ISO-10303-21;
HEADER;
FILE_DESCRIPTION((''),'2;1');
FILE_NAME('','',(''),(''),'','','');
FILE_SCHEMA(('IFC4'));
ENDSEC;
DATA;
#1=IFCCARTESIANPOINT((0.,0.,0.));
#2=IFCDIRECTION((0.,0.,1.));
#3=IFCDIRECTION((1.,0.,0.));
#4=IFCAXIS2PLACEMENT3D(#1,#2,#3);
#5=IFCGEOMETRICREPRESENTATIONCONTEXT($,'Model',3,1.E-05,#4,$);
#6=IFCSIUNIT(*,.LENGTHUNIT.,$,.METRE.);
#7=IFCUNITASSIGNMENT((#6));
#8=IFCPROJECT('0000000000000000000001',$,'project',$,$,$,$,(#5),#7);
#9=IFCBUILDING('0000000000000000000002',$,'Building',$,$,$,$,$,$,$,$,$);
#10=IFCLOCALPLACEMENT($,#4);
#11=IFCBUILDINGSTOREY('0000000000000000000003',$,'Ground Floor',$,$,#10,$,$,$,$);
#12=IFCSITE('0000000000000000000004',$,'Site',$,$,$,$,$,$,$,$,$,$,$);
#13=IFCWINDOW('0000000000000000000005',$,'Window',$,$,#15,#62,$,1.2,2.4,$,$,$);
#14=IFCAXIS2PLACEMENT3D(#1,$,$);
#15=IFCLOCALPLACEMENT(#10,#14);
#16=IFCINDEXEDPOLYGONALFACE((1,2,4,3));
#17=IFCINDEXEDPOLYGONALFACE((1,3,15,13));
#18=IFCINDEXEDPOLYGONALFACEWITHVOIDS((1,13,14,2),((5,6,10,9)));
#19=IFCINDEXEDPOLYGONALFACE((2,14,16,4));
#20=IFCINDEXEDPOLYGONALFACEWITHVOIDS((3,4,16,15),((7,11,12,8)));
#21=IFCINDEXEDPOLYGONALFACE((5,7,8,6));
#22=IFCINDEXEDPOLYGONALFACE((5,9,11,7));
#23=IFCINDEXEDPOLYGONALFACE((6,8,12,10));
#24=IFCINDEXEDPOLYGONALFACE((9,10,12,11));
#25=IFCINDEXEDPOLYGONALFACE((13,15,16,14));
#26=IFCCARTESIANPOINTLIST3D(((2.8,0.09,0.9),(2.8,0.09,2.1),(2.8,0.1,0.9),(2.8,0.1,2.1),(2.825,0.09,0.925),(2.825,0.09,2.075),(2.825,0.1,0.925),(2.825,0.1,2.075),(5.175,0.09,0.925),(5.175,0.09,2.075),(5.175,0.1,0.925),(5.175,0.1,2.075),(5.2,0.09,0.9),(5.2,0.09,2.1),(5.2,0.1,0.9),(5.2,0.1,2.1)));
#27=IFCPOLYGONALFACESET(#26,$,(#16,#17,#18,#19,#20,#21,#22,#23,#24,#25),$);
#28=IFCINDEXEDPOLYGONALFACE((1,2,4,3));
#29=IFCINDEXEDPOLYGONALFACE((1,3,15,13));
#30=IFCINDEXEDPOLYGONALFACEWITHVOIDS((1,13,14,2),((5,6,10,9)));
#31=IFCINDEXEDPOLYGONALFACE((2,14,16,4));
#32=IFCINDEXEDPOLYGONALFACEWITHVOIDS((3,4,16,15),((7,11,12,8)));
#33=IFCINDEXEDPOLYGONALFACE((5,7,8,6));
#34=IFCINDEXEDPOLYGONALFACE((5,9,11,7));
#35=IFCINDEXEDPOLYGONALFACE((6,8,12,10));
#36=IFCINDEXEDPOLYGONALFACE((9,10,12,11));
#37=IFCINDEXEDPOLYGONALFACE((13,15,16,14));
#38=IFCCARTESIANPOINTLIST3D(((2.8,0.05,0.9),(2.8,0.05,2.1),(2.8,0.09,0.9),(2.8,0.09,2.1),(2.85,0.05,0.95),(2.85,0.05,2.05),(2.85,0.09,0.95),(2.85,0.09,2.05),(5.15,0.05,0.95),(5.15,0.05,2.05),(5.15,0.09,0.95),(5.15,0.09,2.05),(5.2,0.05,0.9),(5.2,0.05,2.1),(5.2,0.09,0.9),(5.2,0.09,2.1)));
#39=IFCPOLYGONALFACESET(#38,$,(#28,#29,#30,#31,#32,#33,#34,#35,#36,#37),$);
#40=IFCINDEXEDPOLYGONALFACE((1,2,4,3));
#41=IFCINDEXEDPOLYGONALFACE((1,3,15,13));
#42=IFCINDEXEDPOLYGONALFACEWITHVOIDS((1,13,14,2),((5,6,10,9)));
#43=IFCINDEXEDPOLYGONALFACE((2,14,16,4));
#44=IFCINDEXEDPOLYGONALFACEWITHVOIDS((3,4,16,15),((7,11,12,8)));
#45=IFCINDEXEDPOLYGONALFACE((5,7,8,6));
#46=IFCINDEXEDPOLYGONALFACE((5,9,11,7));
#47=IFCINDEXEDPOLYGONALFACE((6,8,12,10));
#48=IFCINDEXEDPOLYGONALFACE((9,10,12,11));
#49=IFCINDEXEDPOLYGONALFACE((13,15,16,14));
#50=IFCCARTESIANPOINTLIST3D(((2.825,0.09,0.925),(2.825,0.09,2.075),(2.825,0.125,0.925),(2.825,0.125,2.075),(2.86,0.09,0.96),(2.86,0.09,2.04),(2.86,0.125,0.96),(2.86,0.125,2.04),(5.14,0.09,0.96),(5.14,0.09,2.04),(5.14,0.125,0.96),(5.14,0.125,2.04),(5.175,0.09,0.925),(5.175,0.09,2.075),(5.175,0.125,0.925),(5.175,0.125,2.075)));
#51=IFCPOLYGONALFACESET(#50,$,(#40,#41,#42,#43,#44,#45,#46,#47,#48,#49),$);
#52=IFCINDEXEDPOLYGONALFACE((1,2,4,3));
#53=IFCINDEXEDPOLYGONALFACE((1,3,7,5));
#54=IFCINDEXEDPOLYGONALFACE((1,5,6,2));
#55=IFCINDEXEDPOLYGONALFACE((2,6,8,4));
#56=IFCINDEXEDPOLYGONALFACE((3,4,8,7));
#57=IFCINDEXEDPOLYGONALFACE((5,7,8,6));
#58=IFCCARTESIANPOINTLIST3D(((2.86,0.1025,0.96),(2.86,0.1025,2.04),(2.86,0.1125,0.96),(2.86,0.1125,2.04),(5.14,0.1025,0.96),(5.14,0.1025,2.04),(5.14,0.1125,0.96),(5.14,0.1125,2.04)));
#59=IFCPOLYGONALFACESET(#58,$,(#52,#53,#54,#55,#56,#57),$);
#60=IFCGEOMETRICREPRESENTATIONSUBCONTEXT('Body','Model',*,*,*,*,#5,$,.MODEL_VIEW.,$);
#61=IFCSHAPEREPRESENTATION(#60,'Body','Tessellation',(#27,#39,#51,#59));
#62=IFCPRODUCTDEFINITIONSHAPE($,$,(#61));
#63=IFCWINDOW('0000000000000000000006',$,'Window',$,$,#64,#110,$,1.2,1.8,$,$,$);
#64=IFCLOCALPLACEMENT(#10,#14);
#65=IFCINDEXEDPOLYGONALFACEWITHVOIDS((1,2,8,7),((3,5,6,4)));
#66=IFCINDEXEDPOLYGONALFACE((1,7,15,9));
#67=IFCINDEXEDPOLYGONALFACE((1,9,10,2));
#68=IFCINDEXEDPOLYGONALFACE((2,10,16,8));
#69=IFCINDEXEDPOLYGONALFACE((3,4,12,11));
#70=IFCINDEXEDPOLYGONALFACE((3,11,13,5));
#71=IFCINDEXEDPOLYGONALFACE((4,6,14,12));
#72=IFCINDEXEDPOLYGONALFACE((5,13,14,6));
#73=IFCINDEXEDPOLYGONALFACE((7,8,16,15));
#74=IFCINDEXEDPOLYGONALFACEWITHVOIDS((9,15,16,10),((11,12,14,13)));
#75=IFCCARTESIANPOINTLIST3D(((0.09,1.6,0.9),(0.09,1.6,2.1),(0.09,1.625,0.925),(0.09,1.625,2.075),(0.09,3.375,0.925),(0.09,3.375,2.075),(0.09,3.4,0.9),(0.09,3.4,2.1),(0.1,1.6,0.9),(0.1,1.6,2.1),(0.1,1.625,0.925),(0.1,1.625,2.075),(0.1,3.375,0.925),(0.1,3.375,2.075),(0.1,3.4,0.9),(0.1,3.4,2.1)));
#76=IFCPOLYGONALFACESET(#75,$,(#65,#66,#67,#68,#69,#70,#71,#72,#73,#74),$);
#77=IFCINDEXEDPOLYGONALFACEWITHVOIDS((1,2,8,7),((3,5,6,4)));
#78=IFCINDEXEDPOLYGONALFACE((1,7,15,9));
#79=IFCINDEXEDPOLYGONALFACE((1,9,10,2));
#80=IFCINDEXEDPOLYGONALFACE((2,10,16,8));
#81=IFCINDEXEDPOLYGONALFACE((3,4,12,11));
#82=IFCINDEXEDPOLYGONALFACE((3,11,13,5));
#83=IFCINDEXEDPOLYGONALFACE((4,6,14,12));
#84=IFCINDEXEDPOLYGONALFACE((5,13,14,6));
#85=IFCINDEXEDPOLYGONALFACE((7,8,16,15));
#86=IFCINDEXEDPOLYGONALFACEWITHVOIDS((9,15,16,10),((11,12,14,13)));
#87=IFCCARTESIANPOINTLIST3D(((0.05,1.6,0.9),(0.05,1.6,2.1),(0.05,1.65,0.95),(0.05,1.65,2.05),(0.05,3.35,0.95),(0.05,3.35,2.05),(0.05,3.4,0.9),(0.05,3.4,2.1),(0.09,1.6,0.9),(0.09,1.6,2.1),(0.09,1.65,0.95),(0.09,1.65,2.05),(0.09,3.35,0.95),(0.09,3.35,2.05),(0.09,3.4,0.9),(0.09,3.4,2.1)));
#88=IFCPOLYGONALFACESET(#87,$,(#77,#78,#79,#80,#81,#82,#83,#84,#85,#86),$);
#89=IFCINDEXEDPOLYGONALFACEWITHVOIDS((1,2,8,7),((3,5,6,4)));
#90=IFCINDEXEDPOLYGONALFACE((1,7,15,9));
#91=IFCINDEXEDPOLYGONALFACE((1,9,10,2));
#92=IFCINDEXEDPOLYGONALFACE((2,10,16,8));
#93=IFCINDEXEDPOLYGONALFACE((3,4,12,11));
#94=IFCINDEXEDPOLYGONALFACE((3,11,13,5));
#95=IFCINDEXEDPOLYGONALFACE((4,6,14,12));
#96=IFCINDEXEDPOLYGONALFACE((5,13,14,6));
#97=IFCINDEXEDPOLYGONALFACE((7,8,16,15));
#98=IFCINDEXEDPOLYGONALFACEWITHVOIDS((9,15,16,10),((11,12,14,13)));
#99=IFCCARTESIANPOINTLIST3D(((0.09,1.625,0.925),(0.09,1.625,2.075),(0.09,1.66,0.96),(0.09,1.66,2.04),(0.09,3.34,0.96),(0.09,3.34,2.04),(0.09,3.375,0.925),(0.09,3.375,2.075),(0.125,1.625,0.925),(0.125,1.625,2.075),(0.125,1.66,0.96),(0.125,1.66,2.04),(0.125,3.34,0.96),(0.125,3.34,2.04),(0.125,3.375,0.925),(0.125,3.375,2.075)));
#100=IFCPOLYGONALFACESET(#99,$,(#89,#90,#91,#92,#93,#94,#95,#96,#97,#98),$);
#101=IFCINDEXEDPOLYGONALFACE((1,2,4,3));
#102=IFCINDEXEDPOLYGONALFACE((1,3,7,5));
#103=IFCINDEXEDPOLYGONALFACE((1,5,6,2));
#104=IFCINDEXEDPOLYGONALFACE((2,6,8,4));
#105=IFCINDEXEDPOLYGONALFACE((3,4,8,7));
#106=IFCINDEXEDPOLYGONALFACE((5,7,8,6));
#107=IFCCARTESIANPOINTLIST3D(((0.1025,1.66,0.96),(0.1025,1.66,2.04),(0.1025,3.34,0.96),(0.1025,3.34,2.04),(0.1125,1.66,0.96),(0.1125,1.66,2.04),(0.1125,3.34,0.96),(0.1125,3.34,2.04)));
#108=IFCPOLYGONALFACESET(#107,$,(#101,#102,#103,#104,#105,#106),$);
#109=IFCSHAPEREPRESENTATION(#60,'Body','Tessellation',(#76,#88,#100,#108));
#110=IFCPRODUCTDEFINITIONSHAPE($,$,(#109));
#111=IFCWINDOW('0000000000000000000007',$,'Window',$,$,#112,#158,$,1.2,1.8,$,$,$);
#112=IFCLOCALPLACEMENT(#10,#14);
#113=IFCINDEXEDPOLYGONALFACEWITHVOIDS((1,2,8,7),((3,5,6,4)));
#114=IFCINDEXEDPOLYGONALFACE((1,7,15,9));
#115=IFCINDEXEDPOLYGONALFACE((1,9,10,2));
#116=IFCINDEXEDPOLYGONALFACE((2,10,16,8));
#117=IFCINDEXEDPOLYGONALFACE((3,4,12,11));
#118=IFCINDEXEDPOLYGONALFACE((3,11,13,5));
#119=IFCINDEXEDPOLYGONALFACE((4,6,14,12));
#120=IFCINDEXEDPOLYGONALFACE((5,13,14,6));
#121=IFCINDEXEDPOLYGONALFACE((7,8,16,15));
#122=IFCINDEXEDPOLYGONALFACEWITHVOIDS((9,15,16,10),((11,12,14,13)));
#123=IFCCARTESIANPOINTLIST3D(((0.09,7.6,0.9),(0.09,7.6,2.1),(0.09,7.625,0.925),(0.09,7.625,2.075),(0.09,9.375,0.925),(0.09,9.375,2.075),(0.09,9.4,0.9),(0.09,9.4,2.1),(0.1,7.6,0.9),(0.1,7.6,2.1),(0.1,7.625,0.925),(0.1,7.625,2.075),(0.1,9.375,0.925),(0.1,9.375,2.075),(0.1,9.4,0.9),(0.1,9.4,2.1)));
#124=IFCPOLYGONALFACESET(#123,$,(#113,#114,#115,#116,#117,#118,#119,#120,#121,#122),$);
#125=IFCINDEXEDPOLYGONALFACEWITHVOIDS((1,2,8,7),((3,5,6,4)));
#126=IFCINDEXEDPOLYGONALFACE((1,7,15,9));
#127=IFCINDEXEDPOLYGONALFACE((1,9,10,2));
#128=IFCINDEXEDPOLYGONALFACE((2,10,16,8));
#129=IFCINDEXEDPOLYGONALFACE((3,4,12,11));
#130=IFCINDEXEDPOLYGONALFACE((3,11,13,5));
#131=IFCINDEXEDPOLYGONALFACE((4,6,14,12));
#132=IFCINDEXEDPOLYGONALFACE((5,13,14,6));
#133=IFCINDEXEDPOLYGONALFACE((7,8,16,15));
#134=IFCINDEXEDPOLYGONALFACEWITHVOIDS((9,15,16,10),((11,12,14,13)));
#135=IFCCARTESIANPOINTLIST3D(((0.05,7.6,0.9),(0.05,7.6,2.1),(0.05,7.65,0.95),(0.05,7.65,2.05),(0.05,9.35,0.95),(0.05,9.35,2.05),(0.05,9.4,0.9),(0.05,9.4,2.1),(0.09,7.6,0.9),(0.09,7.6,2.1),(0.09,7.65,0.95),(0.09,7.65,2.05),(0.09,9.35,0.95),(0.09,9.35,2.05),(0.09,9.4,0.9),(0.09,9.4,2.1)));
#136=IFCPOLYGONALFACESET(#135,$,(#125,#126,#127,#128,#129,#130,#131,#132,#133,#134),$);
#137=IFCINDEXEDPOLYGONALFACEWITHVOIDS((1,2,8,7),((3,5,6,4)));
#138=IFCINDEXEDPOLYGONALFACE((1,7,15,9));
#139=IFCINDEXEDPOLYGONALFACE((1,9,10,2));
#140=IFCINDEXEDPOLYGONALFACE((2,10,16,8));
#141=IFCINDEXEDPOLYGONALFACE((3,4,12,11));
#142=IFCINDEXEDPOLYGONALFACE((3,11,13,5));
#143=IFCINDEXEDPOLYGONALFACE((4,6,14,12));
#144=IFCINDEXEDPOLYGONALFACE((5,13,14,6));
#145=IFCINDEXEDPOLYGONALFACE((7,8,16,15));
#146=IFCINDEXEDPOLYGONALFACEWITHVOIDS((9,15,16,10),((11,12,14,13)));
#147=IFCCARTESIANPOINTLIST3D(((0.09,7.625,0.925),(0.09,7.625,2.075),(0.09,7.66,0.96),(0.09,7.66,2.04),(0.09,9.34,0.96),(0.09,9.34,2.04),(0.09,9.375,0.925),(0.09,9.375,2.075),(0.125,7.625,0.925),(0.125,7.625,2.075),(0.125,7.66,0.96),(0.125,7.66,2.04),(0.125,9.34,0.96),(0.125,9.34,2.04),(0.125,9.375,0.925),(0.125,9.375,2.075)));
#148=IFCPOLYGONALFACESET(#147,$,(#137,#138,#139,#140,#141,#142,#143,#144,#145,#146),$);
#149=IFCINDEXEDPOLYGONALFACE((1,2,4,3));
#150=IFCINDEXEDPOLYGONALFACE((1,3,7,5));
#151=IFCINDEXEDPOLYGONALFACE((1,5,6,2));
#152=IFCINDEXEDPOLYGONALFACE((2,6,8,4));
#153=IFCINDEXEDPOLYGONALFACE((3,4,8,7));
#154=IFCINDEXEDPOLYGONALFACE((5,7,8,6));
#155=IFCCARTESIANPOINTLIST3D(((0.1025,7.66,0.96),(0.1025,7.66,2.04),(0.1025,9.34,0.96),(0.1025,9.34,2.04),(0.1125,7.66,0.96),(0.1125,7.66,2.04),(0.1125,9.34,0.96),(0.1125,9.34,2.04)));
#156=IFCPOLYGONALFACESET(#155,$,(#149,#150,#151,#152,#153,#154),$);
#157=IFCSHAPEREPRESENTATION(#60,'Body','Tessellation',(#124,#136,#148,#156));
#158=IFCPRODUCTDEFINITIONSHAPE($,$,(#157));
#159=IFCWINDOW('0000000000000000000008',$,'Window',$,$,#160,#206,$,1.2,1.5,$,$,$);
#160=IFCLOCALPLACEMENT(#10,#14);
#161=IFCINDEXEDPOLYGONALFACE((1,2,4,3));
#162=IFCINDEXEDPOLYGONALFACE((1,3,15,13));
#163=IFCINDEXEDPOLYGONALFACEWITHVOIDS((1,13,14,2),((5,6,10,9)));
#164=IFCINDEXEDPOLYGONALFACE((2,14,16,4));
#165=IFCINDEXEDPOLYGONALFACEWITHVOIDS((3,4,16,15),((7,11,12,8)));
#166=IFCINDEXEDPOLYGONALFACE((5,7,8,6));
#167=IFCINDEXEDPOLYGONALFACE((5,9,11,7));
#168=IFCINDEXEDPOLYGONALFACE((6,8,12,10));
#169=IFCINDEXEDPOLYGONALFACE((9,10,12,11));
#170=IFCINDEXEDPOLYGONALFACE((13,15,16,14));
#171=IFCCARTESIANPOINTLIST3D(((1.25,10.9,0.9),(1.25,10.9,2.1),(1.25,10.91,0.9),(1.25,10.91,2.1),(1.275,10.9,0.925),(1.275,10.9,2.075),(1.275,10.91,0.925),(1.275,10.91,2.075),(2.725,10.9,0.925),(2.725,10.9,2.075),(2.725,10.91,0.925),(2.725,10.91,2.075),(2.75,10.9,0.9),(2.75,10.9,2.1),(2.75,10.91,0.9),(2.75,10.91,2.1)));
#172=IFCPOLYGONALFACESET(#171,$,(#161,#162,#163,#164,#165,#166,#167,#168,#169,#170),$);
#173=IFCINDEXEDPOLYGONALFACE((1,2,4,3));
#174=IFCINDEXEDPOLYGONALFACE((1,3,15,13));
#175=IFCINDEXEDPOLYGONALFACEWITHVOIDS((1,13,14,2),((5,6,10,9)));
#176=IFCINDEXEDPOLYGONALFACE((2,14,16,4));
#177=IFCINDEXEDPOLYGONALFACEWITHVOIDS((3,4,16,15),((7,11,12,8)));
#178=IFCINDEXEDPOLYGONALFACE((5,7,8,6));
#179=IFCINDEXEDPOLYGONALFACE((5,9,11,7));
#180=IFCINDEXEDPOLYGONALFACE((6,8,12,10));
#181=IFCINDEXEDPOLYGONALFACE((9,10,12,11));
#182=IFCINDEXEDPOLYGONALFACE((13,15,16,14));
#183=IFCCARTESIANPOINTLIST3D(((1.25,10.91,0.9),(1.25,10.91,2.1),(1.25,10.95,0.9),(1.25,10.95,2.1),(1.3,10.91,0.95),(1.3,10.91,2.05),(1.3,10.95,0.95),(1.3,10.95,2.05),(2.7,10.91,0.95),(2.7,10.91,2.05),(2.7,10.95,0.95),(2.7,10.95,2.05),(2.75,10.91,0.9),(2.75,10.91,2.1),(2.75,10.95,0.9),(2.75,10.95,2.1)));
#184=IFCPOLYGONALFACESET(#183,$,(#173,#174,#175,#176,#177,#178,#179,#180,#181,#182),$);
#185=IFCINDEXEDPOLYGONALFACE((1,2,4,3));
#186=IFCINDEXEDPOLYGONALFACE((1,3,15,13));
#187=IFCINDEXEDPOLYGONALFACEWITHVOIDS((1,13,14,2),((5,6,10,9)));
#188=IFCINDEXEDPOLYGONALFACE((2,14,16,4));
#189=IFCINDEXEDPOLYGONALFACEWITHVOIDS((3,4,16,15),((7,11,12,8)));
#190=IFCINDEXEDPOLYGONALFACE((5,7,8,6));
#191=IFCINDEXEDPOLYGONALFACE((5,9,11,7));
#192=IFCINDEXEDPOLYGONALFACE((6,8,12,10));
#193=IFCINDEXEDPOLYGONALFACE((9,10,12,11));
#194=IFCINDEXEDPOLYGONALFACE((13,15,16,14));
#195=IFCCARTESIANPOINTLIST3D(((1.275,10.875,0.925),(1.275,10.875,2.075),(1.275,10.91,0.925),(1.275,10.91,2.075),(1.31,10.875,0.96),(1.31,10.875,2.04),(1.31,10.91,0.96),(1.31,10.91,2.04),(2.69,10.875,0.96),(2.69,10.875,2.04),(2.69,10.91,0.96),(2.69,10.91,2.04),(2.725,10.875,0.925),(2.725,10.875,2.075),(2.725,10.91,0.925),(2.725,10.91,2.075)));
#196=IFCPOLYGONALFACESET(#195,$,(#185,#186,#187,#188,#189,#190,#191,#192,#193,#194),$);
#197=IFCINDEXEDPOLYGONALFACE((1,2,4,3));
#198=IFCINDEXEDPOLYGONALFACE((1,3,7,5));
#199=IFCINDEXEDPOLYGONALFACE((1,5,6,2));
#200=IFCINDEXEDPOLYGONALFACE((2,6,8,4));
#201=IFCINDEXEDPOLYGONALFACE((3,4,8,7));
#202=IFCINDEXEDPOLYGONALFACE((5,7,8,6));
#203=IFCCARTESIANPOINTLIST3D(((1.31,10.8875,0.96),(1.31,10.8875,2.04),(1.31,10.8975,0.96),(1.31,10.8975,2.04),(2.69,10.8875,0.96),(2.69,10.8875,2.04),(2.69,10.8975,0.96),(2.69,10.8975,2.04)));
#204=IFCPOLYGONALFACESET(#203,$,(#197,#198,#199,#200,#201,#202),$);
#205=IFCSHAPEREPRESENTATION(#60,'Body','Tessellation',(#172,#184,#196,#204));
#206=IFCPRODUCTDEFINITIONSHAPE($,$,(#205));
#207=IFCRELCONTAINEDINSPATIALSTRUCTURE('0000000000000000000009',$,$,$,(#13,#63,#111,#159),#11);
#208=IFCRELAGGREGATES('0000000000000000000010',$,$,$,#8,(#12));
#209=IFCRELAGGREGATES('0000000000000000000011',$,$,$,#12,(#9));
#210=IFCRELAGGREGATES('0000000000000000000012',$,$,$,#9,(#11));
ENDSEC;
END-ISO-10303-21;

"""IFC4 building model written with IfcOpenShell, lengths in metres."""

from ifc_helpers import new_model, si_unit, frame, origin_with_axes, place, context, subcontext, project, spatial, line, indexed_curve, outline, extrude, element, save


model = new_model("IFC4")

# Units and contexts
model_context = context("Model", 3, precision=1e-05, world=origin_with_axes())
body_context = subcontext(model_context, "Body", "Model", "MODEL_VIEW")
ifc_project = project(units=[si_unit("LENGTHUNIT", "METRE")], contexts=[model_context])

# Site, building, storey
site = spatial("IfcSite", under=ifc_project, Name="Site")
building = spatial("IfcBuilding", under=site, Name="Building")
storey_placement = place(None, origin_with_axes())
storey = spatial("IfcBuildingStorey", under=building, at=storey_placement, Name="Ground Floor")

# Windows
window_1_placement = place(storey_placement, frame((2.8, 0.0, 0.9), z_axis=(0.0, 0.0, 1.0), x_axis=(1.0, 0.0, 0.0)))
element("IfcWindow", 1, at=window_1_placement, inside=storey, Name="Window", OverallHeight=1.2, OverallWidth=2.4, context=body_context, shape_type="SweptSolid", body=[
    extrude(outline(indexed_curve([(0.0, 0.0), (2.4, 0.0), (2.4, 1.2), (0.0, 1.2)], segments=[line(1, 2, 3, 4, 1)]), holes=[indexed_curve([(0.025, 0.025), (2.375, 0.025), (2.375, 1.175), (0.025, 1.175)], segments=[line(1, 2, 3, 4, 1)])]), frame((0.0, 0.09, 0.0), z_axis=(0.0, -1.0, 0.0), x_axis=(1.0, 0.0, 0.0)), (0.0, 0.0, -1.0), 0.01),
    extrude(outline(indexed_curve([(0.0, 0.0), (2.4, 0.0), (2.4, 1.2), (0.0, 1.2)], segments=[line(1, 2, 3, 4, 1)]), holes=[indexed_curve([(0.05, 0.05), (2.35, 0.05), (2.35, 1.15), (0.05, 1.15)], segments=[line(1, 2, 3, 4, 1)])]), frame((0.0, 0.05, 0.0), z_axis=(0.0, -1.0, 0.0), x_axis=(1.0, 0.0, 0.0)), (0.0, 0.0, -1.0), 0.04),
    extrude(outline(indexed_curve([(0.0, 0.0), (2.35, 0.0), (2.35, 1.15), (0.0, 1.15)], segments=[line(1, 2, 3, 4, 1)]), holes=[indexed_curve([(0.035, 0.035), (2.315, 0.035), (2.315, 1.115), (0.035, 1.115)], segments=[line(1, 2, 3, 4, 1)])]), frame((0.025, 0.09, 0.025), z_axis=(0.0, -1.0, 0.0), x_axis=(1.0, 0.0, 0.0)), (0.0, 0.0, -1.0), 0.035),
    extrude(outline(indexed_curve([(0.035, 0.035), (2.315, 0.035), (2.315, 1.115), (0.035, 1.115)], segments=[line(1, 2, 3, 4, 1)])), frame((0.025, 0.1025, 0.025), z_axis=(0.0, -1.0, 0.0), x_axis=(1.0, 0.0, 0.0)), (0.0, 0.0, -1.0), 0.01),
])
for number, where, z_axis, x_axis, name in (
    (2, (0.0, 3.4, 0.9), (0.0, 0.0, 1.0), (0.0, -1.0, 0.0), "Window"),
    (3, (0.0, 9.4, 0.9), (0.0, 0.0, 1.0), (0.0, -1.0, 0.0), "Window"),
):
    element("IfcWindow", number, at=place(storey_placement, frame(where, z_axis=z_axis, x_axis=x_axis)), inside=storey, Name=name, OverallHeight=1.2, OverallWidth=1.8, context=body_context, shape_type="SweptSolid", body=[
        extrude(outline(indexed_curve([(0.0, 0.0), (1.8, 0.0), (1.8, 1.2), (0.0, 1.2)], segments=[line(1, 2, 3, 4, 1)]), holes=[indexed_curve([(0.025, 0.025), (1.775, 0.025), (1.775, 1.175), (0.025, 1.175)], segments=[line(1, 2, 3, 4, 1)])]), frame((0.0, 0.09, 0.0), z_axis=(0.0, -1.0, 0.0), x_axis=(1.0, 0.0, 0.0)), (0.0, 0.0, -1.0), 0.01),
        extrude(outline(indexed_curve([(0.0, 0.0), (1.8, 0.0), (1.8, 1.2), (0.0, 1.2)], segments=[line(1, 2, 3, 4, 1)]), holes=[indexed_curve([(0.05, 0.05), (1.75, 0.05), (1.75, 1.15), (0.05, 1.15)], segments=[line(1, 2, 3, 4, 1)])]), frame((0.0, 0.05, 0.0), z_axis=(0.0, -1.0, 0.0), x_axis=(1.0, 0.0, 0.0)), (0.0, 0.0, -1.0), 0.04),
        extrude(outline(indexed_curve([(0.0, 0.0), (1.75, 0.0), (1.75, 1.15), (0.0, 1.15)], segments=[line(1, 2, 3, 4, 1)]), holes=[indexed_curve([(0.035, 0.035), (1.715, 0.035), (1.715, 1.115), (0.035, 1.115)], segments=[line(1, 2, 3, 4, 1)])]), frame((0.025, 0.09, 0.025), z_axis=(0.0, -1.0, 0.0), x_axis=(1.0, 0.0, 0.0)), (0.0, 0.0, -1.0), 0.035),
        extrude(outline(indexed_curve([(0.035, 0.035), (1.715, 0.035), (1.715, 1.115), (0.035, 1.115)], segments=[line(1, 2, 3, 4, 1)])), frame((0.025, 0.1025, 0.025), z_axis=(0.0, -1.0, 0.0), x_axis=(1.0, 0.0, 0.0)), (0.0, 0.0, -1.0), 0.01),
    ])
window_2_placement = place(storey_placement, frame((2.75, 11.0, 0.9), z_axis=(0.0, 0.0, 1.0), x_axis=(-1.0, 0.0, 0.0)))
element("IfcWindow", 4, at=window_2_placement, inside=storey, Name="Window", OverallHeight=1.2, OverallWidth=1.5, context=body_context, shape_type="SweptSolid", body=[
    extrude(outline(indexed_curve([(0.0, 0.0), (1.5, 0.0), (1.5, 1.2), (0.0, 1.2)], segments=[line(1, 2, 3, 4, 1)]), holes=[indexed_curve([(0.025, 0.025), (1.475, 0.025), (1.475, 1.175), (0.025, 1.175)], segments=[line(1, 2, 3, 4, 1)])]), frame((0.0, 0.09, 0.0), z_axis=(0.0, -1.0, 0.0), x_axis=(1.0, 0.0, 0.0)), (0.0, 0.0, -1.0), 0.01),
    extrude(outline(indexed_curve([(0.0, 0.0), (1.5, 0.0), (1.5, 1.2), (0.0, 1.2)], segments=[line(1, 2, 3, 4, 1)]), holes=[indexed_curve([(0.05, 0.05), (1.45, 0.05), (1.45, 1.15), (0.05, 1.15)], segments=[line(1, 2, 3, 4, 1)])]), frame((0.0, 0.05, 0.0), z_axis=(0.0, -1.0, 0.0), x_axis=(1.0, 0.0, 0.0)), (0.0, 0.0, -1.0), 0.04),
    extrude(outline(indexed_curve([(0.0, 0.0), (1.45, 0.0), (1.45, 1.15), (0.0, 1.15)], segments=[line(1, 2, 3, 4, 1)]), holes=[indexed_curve([(0.035, 0.035), (1.415, 0.035), (1.415, 1.115), (0.035, 1.115)], segments=[line(1, 2, 3, 4, 1)])]), frame((0.025, 0.09, 0.025), z_axis=(0.0, -1.0, 0.0), x_axis=(1.0, 0.0, 0.0)), (0.0, 0.0, -1.0), 0.035),
    extrude(outline(indexed_curve([(0.035, 0.035), (1.415, 0.035), (1.415, 1.115), (0.035, 1.115)], segments=[line(1, 2, 3, 4, 1)])), frame((0.025, 0.1025, 0.025), z_axis=(0.0, -1.0, 0.0), x_axis=(1.0, 0.0, 0.0)), (0.0, 0.0, -1.0), 0.01),
])

save(model, "model.ifc")
